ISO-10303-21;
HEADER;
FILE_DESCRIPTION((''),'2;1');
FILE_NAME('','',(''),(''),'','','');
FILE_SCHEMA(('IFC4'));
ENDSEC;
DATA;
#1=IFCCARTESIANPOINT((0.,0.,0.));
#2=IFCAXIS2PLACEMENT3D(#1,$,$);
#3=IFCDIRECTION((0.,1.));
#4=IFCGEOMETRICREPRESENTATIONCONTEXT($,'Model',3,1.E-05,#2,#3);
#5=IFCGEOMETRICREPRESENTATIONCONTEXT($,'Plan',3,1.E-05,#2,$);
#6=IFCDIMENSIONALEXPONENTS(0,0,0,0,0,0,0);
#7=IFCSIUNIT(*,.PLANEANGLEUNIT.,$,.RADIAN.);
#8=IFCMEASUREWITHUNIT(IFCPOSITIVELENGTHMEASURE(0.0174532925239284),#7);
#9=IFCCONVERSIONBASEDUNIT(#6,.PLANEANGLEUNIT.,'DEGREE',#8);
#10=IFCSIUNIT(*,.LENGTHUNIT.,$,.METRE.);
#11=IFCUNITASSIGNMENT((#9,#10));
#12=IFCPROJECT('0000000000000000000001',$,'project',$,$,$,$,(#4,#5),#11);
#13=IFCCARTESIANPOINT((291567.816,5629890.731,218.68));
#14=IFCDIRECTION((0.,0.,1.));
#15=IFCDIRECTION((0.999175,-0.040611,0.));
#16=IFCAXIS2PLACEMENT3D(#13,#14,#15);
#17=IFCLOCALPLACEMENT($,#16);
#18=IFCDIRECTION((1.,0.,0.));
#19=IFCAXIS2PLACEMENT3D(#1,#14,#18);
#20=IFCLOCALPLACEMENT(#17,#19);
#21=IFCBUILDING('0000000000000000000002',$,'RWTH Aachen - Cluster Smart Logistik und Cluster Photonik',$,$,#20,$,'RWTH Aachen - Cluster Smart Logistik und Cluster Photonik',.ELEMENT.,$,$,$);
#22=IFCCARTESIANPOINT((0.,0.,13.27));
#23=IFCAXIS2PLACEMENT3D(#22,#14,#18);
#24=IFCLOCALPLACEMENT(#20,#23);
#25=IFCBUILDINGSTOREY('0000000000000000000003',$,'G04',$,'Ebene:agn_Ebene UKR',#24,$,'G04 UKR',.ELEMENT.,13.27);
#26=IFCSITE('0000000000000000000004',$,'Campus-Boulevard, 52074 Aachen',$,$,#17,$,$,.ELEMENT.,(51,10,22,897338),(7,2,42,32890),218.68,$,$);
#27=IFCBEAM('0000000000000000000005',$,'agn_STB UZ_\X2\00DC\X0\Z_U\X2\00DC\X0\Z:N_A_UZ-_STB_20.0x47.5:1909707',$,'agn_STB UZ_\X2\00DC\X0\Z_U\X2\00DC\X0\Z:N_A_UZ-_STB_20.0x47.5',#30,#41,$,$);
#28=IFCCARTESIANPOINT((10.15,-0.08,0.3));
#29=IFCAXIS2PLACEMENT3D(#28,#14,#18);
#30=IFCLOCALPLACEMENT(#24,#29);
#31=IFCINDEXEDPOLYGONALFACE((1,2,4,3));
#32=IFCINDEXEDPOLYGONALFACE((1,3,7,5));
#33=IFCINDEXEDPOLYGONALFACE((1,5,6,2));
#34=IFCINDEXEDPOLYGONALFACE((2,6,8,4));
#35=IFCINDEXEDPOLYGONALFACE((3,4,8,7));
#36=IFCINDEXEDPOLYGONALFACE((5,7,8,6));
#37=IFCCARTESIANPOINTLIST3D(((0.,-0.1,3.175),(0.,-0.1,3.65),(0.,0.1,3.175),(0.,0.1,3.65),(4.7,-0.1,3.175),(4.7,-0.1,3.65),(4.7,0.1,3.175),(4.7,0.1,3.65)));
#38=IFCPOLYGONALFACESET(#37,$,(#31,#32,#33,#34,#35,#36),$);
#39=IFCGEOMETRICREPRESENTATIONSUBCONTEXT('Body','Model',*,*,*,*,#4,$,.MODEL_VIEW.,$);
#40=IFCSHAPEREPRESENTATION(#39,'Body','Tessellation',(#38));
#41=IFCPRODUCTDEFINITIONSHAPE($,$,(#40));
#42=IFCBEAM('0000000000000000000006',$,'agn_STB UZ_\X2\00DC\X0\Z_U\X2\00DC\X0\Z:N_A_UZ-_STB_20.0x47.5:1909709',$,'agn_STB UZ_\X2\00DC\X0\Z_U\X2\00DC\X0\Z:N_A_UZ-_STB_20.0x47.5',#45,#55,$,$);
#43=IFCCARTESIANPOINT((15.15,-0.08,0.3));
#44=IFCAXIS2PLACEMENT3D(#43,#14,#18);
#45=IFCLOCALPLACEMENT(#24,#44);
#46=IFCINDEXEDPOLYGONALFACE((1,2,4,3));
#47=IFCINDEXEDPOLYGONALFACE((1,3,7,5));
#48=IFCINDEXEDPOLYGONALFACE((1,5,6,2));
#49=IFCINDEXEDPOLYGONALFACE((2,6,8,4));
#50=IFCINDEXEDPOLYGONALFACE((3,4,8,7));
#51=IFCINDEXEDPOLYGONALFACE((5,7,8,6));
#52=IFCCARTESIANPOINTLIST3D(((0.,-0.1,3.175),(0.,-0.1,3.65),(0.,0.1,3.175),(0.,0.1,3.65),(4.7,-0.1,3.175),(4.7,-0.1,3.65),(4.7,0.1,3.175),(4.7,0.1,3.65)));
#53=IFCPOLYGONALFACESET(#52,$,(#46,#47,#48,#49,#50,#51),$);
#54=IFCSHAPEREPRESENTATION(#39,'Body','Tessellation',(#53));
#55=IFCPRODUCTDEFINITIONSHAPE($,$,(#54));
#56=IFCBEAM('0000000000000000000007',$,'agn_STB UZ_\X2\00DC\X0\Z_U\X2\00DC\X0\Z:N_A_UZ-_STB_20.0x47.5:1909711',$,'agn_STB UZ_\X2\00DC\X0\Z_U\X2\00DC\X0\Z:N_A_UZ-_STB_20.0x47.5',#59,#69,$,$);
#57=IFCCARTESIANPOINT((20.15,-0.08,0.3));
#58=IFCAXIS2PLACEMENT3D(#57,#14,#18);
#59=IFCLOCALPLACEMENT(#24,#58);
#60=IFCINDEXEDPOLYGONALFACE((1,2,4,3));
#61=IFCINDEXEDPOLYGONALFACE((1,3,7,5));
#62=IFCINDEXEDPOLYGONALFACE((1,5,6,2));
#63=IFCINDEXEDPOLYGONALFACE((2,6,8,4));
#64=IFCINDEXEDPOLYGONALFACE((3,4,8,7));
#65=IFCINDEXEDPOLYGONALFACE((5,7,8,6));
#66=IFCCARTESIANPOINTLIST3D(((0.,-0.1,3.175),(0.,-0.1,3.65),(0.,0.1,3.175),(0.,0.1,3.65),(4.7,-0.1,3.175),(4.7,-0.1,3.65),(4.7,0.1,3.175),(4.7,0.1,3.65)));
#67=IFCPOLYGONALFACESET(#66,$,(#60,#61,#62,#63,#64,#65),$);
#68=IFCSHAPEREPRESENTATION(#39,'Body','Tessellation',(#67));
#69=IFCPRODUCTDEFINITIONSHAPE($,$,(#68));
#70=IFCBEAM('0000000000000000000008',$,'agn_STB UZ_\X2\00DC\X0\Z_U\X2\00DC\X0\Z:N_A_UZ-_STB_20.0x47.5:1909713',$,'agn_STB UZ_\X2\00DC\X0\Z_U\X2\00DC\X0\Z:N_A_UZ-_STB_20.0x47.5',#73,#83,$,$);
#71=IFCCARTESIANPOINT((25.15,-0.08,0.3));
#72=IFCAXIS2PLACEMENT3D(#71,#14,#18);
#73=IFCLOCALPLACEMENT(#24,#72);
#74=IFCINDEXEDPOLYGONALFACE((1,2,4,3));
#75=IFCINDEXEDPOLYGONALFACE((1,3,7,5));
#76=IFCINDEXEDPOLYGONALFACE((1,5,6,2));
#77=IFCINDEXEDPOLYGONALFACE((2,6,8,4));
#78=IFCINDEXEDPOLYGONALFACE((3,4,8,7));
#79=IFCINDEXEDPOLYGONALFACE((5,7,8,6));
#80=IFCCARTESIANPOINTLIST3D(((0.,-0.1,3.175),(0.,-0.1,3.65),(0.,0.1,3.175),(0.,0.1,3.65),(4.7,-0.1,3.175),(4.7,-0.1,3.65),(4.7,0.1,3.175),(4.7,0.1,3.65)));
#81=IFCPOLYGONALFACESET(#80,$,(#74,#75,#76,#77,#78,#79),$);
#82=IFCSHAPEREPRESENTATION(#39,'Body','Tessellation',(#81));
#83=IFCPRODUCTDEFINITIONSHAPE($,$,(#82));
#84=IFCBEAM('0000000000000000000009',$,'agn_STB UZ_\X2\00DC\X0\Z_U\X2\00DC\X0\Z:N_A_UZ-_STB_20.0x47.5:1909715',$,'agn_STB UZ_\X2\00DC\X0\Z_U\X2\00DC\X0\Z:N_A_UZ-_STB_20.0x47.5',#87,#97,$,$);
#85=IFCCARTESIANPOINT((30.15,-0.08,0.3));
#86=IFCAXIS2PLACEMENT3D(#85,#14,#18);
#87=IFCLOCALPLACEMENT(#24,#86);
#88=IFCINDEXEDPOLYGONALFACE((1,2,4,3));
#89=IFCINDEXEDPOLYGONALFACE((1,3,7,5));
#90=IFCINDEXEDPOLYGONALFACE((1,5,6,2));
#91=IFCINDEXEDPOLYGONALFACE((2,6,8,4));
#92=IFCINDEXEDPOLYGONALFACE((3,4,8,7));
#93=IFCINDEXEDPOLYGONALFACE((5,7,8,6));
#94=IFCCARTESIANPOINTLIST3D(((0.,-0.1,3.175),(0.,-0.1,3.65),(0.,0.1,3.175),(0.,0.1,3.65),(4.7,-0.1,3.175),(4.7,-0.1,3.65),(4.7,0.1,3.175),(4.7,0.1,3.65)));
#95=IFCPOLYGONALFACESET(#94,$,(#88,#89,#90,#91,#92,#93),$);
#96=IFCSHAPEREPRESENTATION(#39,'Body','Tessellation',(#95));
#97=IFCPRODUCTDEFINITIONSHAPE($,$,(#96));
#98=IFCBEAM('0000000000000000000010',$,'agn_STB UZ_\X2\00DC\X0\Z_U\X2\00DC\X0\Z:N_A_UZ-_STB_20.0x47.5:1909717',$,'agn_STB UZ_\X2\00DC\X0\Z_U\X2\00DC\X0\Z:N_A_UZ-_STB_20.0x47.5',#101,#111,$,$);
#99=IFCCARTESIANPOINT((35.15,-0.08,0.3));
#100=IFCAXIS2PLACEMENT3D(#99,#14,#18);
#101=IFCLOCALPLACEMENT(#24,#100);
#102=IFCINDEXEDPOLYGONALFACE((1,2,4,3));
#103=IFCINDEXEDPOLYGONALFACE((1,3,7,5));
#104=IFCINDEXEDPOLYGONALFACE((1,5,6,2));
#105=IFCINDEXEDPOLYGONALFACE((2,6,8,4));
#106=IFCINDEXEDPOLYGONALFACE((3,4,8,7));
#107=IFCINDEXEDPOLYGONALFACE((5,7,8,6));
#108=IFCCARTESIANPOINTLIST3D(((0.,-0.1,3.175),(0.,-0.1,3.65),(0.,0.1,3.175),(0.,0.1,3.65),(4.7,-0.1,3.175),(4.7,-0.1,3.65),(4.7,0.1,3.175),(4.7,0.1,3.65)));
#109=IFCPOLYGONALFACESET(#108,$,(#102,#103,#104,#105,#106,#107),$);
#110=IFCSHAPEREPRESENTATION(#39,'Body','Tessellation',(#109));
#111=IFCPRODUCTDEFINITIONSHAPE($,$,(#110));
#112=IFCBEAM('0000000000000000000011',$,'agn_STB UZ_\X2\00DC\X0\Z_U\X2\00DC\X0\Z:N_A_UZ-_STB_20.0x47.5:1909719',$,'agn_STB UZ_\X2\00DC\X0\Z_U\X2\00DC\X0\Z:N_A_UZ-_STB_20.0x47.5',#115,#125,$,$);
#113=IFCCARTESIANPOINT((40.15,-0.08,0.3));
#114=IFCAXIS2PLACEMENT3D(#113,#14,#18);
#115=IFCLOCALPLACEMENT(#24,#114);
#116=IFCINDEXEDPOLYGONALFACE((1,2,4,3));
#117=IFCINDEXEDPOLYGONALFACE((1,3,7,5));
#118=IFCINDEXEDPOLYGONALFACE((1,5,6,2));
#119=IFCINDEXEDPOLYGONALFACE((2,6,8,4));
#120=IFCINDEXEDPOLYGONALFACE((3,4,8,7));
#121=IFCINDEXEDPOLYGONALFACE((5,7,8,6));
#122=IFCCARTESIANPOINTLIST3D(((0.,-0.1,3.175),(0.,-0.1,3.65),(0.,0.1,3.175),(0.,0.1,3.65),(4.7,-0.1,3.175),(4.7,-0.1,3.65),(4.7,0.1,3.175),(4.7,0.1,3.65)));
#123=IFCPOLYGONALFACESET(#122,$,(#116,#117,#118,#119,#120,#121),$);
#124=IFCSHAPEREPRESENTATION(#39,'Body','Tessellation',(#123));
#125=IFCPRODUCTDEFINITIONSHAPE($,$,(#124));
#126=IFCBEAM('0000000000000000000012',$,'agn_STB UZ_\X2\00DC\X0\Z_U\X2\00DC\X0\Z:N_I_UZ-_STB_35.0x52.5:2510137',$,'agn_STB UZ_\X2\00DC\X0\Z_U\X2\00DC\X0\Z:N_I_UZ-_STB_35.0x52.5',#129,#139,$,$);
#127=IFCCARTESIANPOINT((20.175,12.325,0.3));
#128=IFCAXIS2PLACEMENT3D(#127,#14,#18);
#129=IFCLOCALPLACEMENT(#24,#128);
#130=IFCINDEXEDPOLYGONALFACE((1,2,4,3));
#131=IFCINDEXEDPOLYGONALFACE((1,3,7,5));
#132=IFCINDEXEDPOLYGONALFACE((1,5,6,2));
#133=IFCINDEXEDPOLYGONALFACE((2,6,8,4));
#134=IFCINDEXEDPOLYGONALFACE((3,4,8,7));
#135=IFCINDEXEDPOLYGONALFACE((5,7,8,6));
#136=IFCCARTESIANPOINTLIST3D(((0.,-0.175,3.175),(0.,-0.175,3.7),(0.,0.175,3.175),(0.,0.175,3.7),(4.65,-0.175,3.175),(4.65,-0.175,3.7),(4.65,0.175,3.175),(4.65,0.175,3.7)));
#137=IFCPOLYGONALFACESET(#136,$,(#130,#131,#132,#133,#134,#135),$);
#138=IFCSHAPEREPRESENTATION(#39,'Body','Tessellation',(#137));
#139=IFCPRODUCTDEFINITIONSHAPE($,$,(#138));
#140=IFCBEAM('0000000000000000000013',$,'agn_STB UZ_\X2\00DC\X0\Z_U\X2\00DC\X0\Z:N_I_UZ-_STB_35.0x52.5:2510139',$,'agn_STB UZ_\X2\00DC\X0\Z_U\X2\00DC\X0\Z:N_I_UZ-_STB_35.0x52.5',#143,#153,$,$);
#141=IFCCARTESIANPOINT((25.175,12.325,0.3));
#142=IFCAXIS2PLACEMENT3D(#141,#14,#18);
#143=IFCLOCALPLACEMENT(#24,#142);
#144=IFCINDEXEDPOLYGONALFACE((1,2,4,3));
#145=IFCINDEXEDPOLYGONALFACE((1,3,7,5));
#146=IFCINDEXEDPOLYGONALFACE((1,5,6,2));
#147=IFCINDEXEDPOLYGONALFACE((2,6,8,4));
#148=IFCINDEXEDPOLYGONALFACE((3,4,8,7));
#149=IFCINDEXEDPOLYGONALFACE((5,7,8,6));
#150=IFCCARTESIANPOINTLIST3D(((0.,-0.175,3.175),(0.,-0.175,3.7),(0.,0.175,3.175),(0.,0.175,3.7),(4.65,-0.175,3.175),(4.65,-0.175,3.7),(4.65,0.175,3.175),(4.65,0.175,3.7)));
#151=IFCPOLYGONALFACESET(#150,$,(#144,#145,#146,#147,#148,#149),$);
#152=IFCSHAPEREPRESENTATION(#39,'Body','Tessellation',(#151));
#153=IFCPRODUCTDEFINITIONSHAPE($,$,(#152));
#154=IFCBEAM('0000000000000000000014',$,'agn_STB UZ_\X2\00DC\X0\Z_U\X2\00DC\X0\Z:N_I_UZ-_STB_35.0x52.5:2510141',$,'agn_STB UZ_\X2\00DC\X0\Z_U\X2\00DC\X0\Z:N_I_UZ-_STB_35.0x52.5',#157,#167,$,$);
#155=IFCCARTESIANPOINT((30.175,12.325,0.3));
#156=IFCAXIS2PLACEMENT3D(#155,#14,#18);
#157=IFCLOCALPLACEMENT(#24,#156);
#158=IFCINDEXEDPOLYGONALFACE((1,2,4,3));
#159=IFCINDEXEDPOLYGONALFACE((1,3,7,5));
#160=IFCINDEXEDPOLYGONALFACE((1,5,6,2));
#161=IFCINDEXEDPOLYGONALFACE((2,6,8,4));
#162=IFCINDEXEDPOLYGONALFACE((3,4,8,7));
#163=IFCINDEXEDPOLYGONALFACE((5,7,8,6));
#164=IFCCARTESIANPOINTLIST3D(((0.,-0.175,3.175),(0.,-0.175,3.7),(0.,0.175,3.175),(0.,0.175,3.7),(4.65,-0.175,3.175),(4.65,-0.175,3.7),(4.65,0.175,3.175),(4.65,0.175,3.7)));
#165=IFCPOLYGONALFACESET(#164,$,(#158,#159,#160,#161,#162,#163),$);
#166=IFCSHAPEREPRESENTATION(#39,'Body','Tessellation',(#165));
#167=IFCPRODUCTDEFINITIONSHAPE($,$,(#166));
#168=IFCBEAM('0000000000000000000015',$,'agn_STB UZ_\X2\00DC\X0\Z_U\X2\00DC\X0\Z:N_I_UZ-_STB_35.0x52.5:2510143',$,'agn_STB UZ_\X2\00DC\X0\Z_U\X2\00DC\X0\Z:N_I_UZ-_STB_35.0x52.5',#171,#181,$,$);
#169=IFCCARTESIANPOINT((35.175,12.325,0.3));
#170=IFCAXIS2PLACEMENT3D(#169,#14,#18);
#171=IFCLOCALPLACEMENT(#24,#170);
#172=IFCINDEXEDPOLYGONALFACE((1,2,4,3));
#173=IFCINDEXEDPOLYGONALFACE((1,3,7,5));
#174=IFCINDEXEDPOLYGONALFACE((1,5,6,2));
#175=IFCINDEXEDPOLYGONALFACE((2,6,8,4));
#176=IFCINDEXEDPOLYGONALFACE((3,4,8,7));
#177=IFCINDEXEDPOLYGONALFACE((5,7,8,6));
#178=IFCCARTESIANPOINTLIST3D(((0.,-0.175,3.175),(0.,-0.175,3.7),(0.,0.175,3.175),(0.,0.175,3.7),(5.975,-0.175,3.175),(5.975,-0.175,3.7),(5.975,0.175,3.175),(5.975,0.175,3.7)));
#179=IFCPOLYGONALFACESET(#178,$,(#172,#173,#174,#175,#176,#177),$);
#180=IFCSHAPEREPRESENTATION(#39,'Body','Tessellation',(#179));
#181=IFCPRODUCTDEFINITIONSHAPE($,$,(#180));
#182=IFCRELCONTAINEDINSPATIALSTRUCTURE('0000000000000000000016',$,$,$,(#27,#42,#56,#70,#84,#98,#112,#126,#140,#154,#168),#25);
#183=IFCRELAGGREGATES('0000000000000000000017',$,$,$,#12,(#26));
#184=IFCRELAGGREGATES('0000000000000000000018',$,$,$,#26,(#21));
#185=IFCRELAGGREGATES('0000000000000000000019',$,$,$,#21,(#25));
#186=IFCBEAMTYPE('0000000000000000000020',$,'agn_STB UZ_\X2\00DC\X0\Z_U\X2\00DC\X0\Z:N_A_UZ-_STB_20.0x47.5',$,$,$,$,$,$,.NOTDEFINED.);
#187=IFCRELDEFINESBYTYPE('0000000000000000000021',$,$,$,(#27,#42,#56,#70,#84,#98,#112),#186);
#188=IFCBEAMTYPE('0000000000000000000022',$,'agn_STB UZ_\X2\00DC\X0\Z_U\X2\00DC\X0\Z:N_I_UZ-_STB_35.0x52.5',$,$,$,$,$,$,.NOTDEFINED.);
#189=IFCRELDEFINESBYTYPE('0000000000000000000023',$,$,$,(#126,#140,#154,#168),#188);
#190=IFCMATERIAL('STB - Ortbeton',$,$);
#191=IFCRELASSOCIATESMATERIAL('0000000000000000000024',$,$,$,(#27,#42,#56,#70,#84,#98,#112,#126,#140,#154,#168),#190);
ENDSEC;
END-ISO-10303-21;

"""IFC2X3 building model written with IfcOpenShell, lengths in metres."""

from ifc_helpers import new_model, entity, si_unit, converted_unit, direction, frame, frame_2d, origin, origin_with_axes, place, context, subcontext, project, spatial, rectangle, extrude, material, type_object, element, save


model = new_model("IFC2X3")

# Units and contexts
model_context = context("Model", 3, precision=1e-05, world=origin(), true_north=direction((0.0, 1.0)))
plan_context = context("Plan", 3, precision=1e-05, world=origin())
body_context = subcontext(model_context, "Body", "Model", "MODEL_VIEW")
ifc_project = project(units=[converted_unit("PLANEANGLEUNIT", "DEGREE", entity("IfcPositiveLengthMeasure", 0.0174532925239284), si_unit("PLANEANGLEUNIT", "RADIAN"), dimensions=[0, 0, 0, 0, 0, 0, 0]), si_unit("LENGTHUNIT", "METRE")], contexts=[model_context, plan_context])

# Site, building, storey
site_placement = place(None, frame((291567.816, 5629890.731, 218.68), z_axis=(0.0, 0.0, 1.0), x_axis=(0.999175, -0.040611, 0.0)))
site = spatial("IfcSite", under=ifc_project, at=site_placement, Name="Campus-Boulevard, 52074 Aachen", CompositionType="ELEMENT", RefLatitude=(51, 10, 22, 897338), RefLongitude=(7, 2, 42, 32890), RefElevation=218.68)
building_placement = place(site_placement, origin_with_axes())
building = spatial("IfcBuilding", under=site, at=building_placement, Name="RWTH Aachen - Cluster Smart Logistik und Cluster Photonik", LongName="RWTH Aachen - Cluster Smart Logistik und Cluster Photonik", CompositionType="ELEMENT")
storey_placement = place(building_placement, frame((0.0, 0.0, 13.27), z_axis=(0.0, 0.0, 1.0), x_axis=(1.0, 0.0, 0.0)))
storey = spatial("IfcBuildingStorey", under=building, at=storey_placement, Name="G04", ObjectType="Ebene:agn_Ebene UKR", LongName="G04 UKR", CompositionType="ELEMENT", Elevation=13.27)

# Beams
ifc_material_1 = material(Name="STB - Ortbeton")
beam_type_1 = type_object("IfcBeamType", Name="agn_STB UZ_ÜZ_UÜZ:N_A_UZ-_STB_20.0x47.5", PredefinedType="NOTDEFINED")
for number, where, z_axis, x_axis, name in (
    (1, (10.15, -0.08, 0.3), (0.0, 0.0, 1.0), (1.0, 0.0, 0.0), "agn_STB UZ_ÜZ_UÜZ:N_A_UZ-_STB_20.0x47.5:1909707"),
    (2, (15.15, -0.08, 0.3), (0.0, 0.0, 1.0), (1.0, 0.0, 0.0), "agn_STB UZ_ÜZ_UÜZ:N_A_UZ-_STB_20.0x47.5:1909709"),
    (3, (20.15, -0.08, 0.3), (0.0, 0.0, 1.0), (1.0, 0.0, 0.0), "agn_STB UZ_ÜZ_UÜZ:N_A_UZ-_STB_20.0x47.5:1909711"),
    (4, (25.15, -0.08, 0.3), (0.0, 0.0, 1.0), (1.0, 0.0, 0.0), "agn_STB UZ_ÜZ_UÜZ:N_A_UZ-_STB_20.0x47.5:1909713"),
    (5, (30.15, -0.08, 0.3), (0.0, 0.0, 1.0), (1.0, 0.0, 0.0), "agn_STB UZ_ÜZ_UÜZ:N_A_UZ-_STB_20.0x47.5:1909715"),
    (6, (35.15, -0.08, 0.3), (0.0, 0.0, 1.0), (1.0, 0.0, 0.0), "agn_STB UZ_ÜZ_UÜZ:N_A_UZ-_STB_20.0x47.5:1909717"),
    (7, (40.15, -0.08, 0.3), (0.0, 0.0, 1.0), (1.0, 0.0, 0.0), "agn_STB UZ_ÜZ_UÜZ:N_A_UZ-_STB_20.0x47.5:1909719"),
):
    element("IfcBeam", number, at=place(storey_placement, frame(where, z_axis=z_axis, x_axis=x_axis)), inside=storey, type_object=beam_type_1, material=ifc_material_1, Name=name, ObjectType="agn_STB UZ_ÜZ_UÜZ:N_A_UZ-_STB_20.0x47.5", context=body_context, shape_type="SweptSolid", body=[
        extrude(rectangle(XDim=0.475, YDim=0.2, at=frame_2d((0.0, 0.0), x_axis=(1.0, 0.0))), frame((0.0, 0.0, 3.4125), z_axis=(1.0, 0.0, 0.0), x_axis=(0.0, 0.0, -1.0)), (0.0, 0.0, 1.0), 4.7),
    ])
beam_type_2 = type_object("IfcBeamType", Name="agn_STB UZ_ÜZ_UÜZ:N_I_UZ-_STB_35.0x52.5", PredefinedType="NOTDEFINED")
for number, where, z_axis, x_axis, name in (
    (8, (20.175, 12.325, 0.3), (0.0, 0.0, 1.0), (1.0, 0.0, 0.0), "agn_STB UZ_ÜZ_UÜZ:N_I_UZ-_STB_35.0x52.5:2510137"),
    (9, (25.175, 12.325, 0.3), (0.0, 0.0, 1.0), (1.0, 0.0, 0.0), "agn_STB UZ_ÜZ_UÜZ:N_I_UZ-_STB_35.0x52.5:2510139"),
    (10, (30.175, 12.325, 0.3), (0.0, 0.0, 1.0), (1.0, 0.0, 0.0), "agn_STB UZ_ÜZ_UÜZ:N_I_UZ-_STB_35.0x52.5:2510141"),
):
    element("IfcBeam", number, at=place(storey_placement, frame(where, z_axis=z_axis, x_axis=x_axis)), inside=storey, type_object=beam_type_2, material=ifc_material_1, Name=name, ObjectType="agn_STB UZ_ÜZ_UÜZ:N_I_UZ-_STB_35.0x52.5", context=body_context, shape_type="SweptSolid", body=[
        extrude(rectangle(XDim=0.525, YDim=0.35, at=frame_2d((0.0, 0.0), x_axis=(1.0, 0.0))), frame((0.0, 0.0, 3.4375), z_axis=(1.0, 0.0, 0.0), x_axis=(0.0, 0.0, -1.0)), (0.0, 0.0, 1.0), 4.65),
    ])
beam_1_placement = place(storey_placement, frame((35.175, 12.325, 0.3), z_axis=(0.0, 0.0, 1.0), x_axis=(1.0, 0.0, 0.0)))
element("IfcBeam", 11, at=beam_1_placement, inside=storey, type_object=beam_type_2, material=ifc_material_1, Name="agn_STB UZ_ÜZ_UÜZ:N_I_UZ-_STB_35.0x52.5:2510143", ObjectType="agn_STB UZ_ÜZ_UÜZ:N_I_UZ-_STB_35.0x52.5", context=body_context, shape_type="SweptSolid", body=[
    extrude(rectangle(XDim=0.525, YDim=0.35, at=frame_2d((0.0, 0.0), x_axis=(1.0, 0.0))), frame((0.0, 0.0, 3.4375), z_axis=(1.0, 0.0, 0.0), x_axis=(0.0, 0.0, -1.0)), (0.0, 0.0, 1.0), 5.975),
])

save(model, "model.ifc")
